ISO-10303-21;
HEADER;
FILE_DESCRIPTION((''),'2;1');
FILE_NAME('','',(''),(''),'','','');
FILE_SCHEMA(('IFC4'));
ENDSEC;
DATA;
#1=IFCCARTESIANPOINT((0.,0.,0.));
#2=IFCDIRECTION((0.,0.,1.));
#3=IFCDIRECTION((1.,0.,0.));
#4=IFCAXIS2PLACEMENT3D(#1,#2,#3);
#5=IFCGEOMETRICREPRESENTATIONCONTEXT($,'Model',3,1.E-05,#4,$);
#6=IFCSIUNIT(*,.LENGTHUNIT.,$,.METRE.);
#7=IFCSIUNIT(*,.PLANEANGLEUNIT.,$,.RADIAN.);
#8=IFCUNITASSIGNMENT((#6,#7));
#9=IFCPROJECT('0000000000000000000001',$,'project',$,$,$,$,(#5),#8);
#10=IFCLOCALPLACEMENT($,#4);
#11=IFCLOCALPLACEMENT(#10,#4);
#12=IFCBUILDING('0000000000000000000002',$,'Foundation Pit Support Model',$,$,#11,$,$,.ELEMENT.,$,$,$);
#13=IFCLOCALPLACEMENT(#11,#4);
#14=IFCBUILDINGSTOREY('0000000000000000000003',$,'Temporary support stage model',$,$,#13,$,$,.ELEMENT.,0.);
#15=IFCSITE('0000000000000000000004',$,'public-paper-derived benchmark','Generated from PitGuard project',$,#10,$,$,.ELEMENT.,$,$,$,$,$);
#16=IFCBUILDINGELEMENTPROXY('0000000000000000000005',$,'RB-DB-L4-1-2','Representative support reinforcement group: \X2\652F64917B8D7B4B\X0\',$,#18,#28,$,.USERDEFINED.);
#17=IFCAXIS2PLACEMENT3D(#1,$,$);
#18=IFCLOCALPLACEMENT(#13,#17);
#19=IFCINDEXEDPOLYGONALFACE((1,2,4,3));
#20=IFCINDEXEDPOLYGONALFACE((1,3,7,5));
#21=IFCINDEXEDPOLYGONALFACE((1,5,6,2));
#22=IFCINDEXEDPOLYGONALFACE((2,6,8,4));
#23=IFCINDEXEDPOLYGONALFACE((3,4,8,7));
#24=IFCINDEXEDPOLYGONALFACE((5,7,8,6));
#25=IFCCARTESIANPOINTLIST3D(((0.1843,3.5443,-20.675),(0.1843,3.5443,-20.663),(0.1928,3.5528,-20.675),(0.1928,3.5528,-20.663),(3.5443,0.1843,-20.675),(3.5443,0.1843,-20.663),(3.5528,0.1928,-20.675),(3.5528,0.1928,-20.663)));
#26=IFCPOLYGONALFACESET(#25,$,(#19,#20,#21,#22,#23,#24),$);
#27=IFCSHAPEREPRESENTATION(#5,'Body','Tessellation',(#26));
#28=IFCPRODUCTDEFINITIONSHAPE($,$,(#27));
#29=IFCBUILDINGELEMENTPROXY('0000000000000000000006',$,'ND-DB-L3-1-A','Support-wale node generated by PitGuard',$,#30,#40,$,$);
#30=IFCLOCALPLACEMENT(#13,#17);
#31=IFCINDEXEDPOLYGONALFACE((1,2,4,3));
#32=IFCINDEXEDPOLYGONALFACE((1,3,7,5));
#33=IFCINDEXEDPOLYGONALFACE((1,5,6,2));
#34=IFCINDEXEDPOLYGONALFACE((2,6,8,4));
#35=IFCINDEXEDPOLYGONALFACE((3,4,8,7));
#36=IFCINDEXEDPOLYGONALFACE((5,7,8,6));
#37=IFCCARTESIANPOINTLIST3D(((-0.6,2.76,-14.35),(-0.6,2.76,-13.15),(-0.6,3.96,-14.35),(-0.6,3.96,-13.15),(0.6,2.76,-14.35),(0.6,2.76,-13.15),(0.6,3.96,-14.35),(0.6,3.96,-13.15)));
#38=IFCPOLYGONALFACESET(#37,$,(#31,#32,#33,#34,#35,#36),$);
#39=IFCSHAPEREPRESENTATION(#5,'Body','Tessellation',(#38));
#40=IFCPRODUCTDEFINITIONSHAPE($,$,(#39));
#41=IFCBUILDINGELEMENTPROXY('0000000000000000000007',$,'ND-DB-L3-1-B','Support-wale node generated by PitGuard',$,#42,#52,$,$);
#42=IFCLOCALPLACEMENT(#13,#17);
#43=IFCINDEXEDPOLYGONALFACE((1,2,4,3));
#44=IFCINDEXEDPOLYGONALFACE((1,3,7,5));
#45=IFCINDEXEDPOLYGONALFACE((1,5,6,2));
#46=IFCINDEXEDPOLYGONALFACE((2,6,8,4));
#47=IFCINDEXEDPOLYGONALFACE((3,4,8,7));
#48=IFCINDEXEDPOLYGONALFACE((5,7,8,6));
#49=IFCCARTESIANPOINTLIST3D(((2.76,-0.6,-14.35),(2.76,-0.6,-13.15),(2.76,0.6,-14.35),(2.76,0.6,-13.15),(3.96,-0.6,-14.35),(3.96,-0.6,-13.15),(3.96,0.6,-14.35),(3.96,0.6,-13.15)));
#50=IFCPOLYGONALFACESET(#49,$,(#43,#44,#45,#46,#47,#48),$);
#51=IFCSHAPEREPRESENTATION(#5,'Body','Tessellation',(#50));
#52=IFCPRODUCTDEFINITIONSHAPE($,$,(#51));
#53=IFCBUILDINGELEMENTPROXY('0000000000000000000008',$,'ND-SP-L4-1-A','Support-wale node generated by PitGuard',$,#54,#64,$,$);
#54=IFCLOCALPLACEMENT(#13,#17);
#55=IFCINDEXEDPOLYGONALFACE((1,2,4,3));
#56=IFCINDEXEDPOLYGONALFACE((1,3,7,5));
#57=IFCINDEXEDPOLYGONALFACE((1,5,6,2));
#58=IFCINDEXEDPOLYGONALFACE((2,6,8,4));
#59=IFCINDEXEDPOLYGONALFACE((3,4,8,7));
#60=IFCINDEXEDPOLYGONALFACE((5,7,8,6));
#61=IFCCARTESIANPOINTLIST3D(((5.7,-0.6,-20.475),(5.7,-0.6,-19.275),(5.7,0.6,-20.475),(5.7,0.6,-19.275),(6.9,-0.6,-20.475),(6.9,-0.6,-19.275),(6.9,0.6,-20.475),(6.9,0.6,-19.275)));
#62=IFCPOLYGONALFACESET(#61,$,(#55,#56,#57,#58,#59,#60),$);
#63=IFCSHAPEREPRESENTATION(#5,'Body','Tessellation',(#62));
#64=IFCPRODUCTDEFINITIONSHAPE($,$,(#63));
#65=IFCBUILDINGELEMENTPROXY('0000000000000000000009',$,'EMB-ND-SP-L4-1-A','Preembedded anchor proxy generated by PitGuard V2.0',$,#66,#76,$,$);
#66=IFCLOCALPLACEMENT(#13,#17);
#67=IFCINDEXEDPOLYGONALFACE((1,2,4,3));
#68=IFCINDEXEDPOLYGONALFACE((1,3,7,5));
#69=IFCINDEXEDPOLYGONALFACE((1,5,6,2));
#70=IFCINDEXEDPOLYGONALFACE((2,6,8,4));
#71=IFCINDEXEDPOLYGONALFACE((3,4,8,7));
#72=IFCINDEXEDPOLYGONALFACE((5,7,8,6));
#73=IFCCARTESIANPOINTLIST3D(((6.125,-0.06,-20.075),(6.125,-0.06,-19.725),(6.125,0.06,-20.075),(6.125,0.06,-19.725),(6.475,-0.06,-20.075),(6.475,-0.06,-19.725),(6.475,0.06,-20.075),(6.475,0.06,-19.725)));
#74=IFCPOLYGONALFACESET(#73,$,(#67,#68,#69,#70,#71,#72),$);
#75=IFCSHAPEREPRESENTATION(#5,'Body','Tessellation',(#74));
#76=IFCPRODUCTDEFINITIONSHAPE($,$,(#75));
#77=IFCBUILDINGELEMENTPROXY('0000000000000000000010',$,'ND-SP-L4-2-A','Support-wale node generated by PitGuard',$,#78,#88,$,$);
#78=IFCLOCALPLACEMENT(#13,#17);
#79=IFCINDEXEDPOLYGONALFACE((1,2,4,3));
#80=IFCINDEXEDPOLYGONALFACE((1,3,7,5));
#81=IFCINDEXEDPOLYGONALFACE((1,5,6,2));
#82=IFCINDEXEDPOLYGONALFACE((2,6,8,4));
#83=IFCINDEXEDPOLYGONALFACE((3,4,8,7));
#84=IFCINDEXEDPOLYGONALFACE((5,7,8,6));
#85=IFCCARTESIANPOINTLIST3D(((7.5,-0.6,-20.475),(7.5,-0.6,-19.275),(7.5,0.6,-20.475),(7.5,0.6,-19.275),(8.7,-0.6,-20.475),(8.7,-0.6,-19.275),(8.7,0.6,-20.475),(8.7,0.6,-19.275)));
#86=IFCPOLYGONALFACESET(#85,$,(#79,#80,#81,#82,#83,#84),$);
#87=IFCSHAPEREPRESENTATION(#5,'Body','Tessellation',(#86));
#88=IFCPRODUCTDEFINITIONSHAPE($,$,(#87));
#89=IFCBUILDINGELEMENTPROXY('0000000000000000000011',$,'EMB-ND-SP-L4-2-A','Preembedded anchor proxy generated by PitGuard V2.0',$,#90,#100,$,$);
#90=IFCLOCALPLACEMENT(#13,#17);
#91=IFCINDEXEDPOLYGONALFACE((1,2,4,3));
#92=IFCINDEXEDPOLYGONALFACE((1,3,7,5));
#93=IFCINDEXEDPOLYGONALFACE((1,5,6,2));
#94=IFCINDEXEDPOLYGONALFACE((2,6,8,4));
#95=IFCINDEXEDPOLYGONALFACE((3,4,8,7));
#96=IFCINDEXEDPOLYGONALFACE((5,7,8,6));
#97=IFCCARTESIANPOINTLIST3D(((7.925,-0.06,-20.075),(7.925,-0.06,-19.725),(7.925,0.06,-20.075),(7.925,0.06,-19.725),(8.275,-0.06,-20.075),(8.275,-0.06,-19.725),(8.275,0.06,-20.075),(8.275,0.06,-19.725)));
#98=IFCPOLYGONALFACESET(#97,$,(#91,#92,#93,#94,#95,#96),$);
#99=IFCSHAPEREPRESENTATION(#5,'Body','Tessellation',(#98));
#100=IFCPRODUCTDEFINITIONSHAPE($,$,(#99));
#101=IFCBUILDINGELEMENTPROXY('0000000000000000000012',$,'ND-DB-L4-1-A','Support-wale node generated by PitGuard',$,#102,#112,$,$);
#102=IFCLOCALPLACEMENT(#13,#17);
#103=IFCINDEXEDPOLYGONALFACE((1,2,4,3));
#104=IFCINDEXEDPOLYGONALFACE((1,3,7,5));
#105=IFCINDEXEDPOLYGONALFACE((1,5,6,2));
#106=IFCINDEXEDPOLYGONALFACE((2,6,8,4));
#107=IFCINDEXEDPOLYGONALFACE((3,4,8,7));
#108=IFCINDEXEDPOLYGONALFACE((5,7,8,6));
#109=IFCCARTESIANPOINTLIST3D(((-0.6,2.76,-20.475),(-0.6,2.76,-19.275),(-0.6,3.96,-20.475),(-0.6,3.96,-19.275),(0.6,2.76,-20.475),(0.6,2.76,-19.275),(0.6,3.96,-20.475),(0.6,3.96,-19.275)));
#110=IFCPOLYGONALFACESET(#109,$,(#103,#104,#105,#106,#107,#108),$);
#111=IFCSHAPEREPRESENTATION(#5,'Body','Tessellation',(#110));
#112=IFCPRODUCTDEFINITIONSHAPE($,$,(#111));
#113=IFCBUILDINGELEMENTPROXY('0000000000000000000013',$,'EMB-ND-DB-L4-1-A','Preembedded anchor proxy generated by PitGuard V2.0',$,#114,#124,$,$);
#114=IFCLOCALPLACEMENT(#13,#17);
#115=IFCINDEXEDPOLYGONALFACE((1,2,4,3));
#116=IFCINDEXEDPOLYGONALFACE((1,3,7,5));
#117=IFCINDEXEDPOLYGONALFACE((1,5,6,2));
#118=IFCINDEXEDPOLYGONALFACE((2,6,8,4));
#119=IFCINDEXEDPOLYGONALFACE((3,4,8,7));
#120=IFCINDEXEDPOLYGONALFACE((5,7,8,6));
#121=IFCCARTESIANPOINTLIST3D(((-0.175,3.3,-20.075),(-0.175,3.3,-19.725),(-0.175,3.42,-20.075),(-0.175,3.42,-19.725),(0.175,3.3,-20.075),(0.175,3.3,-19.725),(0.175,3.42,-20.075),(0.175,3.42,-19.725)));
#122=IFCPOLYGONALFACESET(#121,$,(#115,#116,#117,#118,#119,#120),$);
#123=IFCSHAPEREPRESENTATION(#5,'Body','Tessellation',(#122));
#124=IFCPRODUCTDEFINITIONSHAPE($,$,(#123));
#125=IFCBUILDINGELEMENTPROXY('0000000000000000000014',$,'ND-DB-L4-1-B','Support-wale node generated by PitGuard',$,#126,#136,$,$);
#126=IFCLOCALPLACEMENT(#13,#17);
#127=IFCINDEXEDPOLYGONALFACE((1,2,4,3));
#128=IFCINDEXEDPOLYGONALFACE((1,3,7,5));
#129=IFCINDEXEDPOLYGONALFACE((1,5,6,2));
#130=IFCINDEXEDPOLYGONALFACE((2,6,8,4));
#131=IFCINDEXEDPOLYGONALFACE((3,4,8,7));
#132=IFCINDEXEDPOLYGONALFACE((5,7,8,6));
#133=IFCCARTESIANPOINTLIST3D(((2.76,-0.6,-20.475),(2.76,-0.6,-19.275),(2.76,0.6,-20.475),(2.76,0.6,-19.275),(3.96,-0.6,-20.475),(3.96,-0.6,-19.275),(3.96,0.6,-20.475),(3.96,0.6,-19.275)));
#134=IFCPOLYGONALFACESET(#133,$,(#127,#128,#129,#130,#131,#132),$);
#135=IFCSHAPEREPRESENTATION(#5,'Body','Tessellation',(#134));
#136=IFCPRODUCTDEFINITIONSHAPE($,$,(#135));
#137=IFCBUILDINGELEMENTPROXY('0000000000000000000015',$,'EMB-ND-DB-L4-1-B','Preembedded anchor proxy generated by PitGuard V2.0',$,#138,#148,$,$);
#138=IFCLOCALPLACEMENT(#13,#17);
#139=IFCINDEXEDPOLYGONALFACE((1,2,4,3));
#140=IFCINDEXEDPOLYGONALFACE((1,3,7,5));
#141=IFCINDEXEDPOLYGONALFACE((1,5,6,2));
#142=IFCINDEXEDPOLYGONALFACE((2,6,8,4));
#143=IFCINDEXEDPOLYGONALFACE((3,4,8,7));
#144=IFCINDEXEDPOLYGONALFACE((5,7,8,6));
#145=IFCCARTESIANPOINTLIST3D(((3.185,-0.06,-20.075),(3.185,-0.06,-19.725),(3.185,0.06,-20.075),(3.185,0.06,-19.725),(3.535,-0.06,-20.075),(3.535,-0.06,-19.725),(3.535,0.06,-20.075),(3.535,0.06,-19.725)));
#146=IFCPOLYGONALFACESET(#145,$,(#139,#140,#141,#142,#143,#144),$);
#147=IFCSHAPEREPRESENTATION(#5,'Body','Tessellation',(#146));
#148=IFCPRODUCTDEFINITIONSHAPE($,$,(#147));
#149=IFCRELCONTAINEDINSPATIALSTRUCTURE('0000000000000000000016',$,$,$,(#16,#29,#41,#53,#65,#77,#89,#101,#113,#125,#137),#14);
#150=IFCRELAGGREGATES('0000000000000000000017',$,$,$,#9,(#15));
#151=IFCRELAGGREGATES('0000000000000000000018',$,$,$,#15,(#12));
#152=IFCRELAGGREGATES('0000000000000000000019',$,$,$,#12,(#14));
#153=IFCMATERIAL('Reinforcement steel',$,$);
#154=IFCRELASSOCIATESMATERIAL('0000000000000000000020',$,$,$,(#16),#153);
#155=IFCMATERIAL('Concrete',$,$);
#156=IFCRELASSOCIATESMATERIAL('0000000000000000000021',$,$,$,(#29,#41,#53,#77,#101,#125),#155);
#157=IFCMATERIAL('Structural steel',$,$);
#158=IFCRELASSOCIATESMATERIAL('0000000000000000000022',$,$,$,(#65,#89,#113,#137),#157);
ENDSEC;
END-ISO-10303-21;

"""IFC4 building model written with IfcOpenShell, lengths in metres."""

from ifc_helpers import new_model, si_unit, frame, origin_with_axes, origin_2d, place, context, project, spatial, rectangle, extrude, material, element, save


model = new_model("IFC4")

# Units and contexts
model_context = context("Model", 3, precision=1e-05, world=origin_with_axes())
ifc_project = project(units=[si_unit("LENGTHUNIT", "METRE"), si_unit("PLANEANGLEUNIT", "RADIAN")], contexts=[model_context])

# Site, building, storey
site_placement = place(None, origin_with_axes())
site = spatial("IfcSite", under=ifc_project, at=site_placement, Name="public-paper-derived benchmark", Description="Generated from PitGuard project", CompositionType="ELEMENT")
building_placement = place(site_placement, origin_with_axes())
building = spatial("IfcBuilding", under=site, at=building_placement, Name="Foundation Pit Support Model", CompositionType="ELEMENT")
storey_placement = place(building_placement, origin_with_axes())
storey = spatial("IfcBuildingStorey", under=building, at=storey_placement, Name="Temporary support stage model", CompositionType="ELEMENT", Elevation=0.0)

# Shared definitions
ifc_material_1 = material(Name="Concrete")

# Shared definitions
ifc_material_2 = material(Name="Structural steel")

# Building element proxies
ifc_material_3 = material(Name="Reinforcement steel")
proxy_1_placement = place(storey_placement, frame((1.8686, 1.8686, -20.675), z_axis=(0.0, 0.0, 1.0), x_axis=(0.707107, -0.707107, 0.0)))
element("IfcBuildingElementProxy", 1, at=proxy_1_placement, inside=storey, material=ifc_material_3, Name="RB-DB-L4-1-2", Description="Representative support reinforcement group: 支撑箍筋", PredefinedType="USERDEFINED", context=model_context, shape_type="SweptSolid", body=[
    extrude(rectangle(XDim=4.7518, YDim=0.012, at=origin_2d()), origin_with_axes(), (0.0, 0.0, 1.0), 0.012),
])
for number, where, z_axis, x_axis, name in (
    (2, (0.0, 3.36, -14.35), (0.0, 0.0, 1.0), (1.0, 0.0, 0.0), "ND-DB-L3-1-A"),
    (3, (3.36, 0.0, -14.35), (0.0, 0.0, 1.0), (1.0, 0.0, 0.0), "ND-DB-L3-1-B"),
    (4, (6.3, 0.0, -20.475), (0.0, 0.0, 1.0), (1.0, 0.0, 0.0), "ND-SP-L4-1-A"),
):
    element("IfcBuildingElementProxy", number, at=place(storey_placement, frame(where, z_axis=z_axis, x_axis=x_axis)), inside=storey, material=ifc_material_1, Name=name, Description="Support-wale node generated by PitGuard", context=model_context, shape_type="SweptSolid", body=[
        extrude(rectangle(XDim=1.2, YDim=1.2, at=origin_2d()), origin_with_axes(), (0.0, 0.0, 1.0), 1.2),
    ])
proxy_2_placement = place(storey_placement, frame((6.3, 0.0, -20.075), z_axis=(0.0, 0.0, 1.0), x_axis=(1.0, 0.0, 0.0)))
element("IfcBuildingElementProxy", 5, at=proxy_2_placement, inside=storey, material=ifc_material_2, Name="EMB-ND-SP-L4-1-A", Description="Preembedded anchor proxy generated by PitGuard V2.0", context=model_context, shape_type="SweptSolid", body=[
    extrude(rectangle(XDim=0.35, YDim=0.12, at=origin_2d()), origin_with_axes(), (0.0, 0.0, 1.0), 0.35),
])
proxy_3_placement = place(storey_placement, frame((8.1, 0.0, -20.475), z_axis=(0.0, 0.0, 1.0), x_axis=(1.0, 0.0, 0.0)))
element("IfcBuildingElementProxy", 6, at=proxy_3_placement, inside=storey, material=ifc_material_1, Name="ND-SP-L4-2-A", Description="Support-wale node generated by PitGuard", context=model_context, shape_type="SweptSolid", body=[
    extrude(rectangle(XDim=1.2, YDim=1.2, at=origin_2d()), origin_with_axes(), (0.0, 0.0, 1.0), 1.2),
])
proxy_4_placement = place(storey_placement, frame((8.1, 0.0, -20.075), z_axis=(0.0, 0.0, 1.0), x_axis=(1.0, 0.0, 0.0)))
element("IfcBuildingElementProxy", 7, at=proxy_4_placement, inside=storey, material=ifc_material_2, Name="EMB-ND-SP-L4-2-A", Description="Preembedded anchor proxy generated by PitGuard V2.0", context=model_context, shape_type="SweptSolid", body=[
    extrude(rectangle(XDim=0.35, YDim=0.12, at=origin_2d()), origin_with_axes(), (0.0, 0.0, 1.0), 0.35),
])
proxy_5_placement = place(storey_placement, frame((0.0, 3.36, -20.475), z_axis=(0.0, 0.0, 1.0), x_axis=(1.0, 0.0, 0.0)))
element("IfcBuildingElementProxy", 8, at=proxy_5_placement, inside=storey, material=ifc_material_1, Name="ND-DB-L4-1-A", Description="Support-wale node generated by PitGuard", context=model_context, shape_type="SweptSolid", body=[
    extrude(rectangle(XDim=1.2, YDim=1.2, at=origin_2d()), origin_with_axes(), (0.0, 0.0, 1.0), 1.2),
])
proxy_6_placement = place(storey_placement, frame((0.0, 3.36, -20.075), z_axis=(0.0, 0.0, 1.0), x_axis=(1.0, 0.0, 0.0)))
element("IfcBuildingElementProxy", 9, at=proxy_6_placement, inside=storey, material=ifc_material_2, Name="EMB-ND-DB-L4-1-A", Description="Preembedded anchor proxy generated by PitGuard V2.0", context=model_context, shape_type="SweptSolid", body=[
    extrude(rectangle(XDim=0.35, YDim=0.12, at=origin_2d()), origin_with_axes(), (0.0, 0.0, 1.0), 0.35),
])
proxy_7_placement = place(storey_placement, frame((3.36, 0.0, -20.475), z_axis=(0.0, 0.0, 1.0), x_axis=(1.0, 0.0, 0.0)))
element("IfcBuildingElementProxy", 10, at=proxy_7_placement, inside=storey, material=ifc_material_1, Name="ND-DB-L4-1-B", Description="Support-wale node generated by PitGuard", context=model_context, shape_type="SweptSolid", body=[
    extrude(rectangle(XDim=1.2, YDim=1.2, at=origin_2d()), origin_with_axes(), (0.0, 0.0, 1.0), 1.2),
])
proxy_8_placement = place(storey_placement, frame((3.36, 0.0, -20.075), z_axis=(0.0, 0.0, 1.0), x_axis=(1.0, 0.0, 0.0)))
element("IfcBuildingElementProxy", 11, at=proxy_8_placement, inside=storey, material=ifc_material_2, Name="EMB-ND-DB-L4-1-B", Description="Preembedded anchor proxy generated by PitGuard V2.0", context=model_context, shape_type="SweptSolid", body=[
    extrude(rectangle(XDim=0.35, YDim=0.12, at=origin_2d()), origin_with_axes(), (0.0, 0.0, 1.0), 0.35),
])

save(model, "model.ifc")
